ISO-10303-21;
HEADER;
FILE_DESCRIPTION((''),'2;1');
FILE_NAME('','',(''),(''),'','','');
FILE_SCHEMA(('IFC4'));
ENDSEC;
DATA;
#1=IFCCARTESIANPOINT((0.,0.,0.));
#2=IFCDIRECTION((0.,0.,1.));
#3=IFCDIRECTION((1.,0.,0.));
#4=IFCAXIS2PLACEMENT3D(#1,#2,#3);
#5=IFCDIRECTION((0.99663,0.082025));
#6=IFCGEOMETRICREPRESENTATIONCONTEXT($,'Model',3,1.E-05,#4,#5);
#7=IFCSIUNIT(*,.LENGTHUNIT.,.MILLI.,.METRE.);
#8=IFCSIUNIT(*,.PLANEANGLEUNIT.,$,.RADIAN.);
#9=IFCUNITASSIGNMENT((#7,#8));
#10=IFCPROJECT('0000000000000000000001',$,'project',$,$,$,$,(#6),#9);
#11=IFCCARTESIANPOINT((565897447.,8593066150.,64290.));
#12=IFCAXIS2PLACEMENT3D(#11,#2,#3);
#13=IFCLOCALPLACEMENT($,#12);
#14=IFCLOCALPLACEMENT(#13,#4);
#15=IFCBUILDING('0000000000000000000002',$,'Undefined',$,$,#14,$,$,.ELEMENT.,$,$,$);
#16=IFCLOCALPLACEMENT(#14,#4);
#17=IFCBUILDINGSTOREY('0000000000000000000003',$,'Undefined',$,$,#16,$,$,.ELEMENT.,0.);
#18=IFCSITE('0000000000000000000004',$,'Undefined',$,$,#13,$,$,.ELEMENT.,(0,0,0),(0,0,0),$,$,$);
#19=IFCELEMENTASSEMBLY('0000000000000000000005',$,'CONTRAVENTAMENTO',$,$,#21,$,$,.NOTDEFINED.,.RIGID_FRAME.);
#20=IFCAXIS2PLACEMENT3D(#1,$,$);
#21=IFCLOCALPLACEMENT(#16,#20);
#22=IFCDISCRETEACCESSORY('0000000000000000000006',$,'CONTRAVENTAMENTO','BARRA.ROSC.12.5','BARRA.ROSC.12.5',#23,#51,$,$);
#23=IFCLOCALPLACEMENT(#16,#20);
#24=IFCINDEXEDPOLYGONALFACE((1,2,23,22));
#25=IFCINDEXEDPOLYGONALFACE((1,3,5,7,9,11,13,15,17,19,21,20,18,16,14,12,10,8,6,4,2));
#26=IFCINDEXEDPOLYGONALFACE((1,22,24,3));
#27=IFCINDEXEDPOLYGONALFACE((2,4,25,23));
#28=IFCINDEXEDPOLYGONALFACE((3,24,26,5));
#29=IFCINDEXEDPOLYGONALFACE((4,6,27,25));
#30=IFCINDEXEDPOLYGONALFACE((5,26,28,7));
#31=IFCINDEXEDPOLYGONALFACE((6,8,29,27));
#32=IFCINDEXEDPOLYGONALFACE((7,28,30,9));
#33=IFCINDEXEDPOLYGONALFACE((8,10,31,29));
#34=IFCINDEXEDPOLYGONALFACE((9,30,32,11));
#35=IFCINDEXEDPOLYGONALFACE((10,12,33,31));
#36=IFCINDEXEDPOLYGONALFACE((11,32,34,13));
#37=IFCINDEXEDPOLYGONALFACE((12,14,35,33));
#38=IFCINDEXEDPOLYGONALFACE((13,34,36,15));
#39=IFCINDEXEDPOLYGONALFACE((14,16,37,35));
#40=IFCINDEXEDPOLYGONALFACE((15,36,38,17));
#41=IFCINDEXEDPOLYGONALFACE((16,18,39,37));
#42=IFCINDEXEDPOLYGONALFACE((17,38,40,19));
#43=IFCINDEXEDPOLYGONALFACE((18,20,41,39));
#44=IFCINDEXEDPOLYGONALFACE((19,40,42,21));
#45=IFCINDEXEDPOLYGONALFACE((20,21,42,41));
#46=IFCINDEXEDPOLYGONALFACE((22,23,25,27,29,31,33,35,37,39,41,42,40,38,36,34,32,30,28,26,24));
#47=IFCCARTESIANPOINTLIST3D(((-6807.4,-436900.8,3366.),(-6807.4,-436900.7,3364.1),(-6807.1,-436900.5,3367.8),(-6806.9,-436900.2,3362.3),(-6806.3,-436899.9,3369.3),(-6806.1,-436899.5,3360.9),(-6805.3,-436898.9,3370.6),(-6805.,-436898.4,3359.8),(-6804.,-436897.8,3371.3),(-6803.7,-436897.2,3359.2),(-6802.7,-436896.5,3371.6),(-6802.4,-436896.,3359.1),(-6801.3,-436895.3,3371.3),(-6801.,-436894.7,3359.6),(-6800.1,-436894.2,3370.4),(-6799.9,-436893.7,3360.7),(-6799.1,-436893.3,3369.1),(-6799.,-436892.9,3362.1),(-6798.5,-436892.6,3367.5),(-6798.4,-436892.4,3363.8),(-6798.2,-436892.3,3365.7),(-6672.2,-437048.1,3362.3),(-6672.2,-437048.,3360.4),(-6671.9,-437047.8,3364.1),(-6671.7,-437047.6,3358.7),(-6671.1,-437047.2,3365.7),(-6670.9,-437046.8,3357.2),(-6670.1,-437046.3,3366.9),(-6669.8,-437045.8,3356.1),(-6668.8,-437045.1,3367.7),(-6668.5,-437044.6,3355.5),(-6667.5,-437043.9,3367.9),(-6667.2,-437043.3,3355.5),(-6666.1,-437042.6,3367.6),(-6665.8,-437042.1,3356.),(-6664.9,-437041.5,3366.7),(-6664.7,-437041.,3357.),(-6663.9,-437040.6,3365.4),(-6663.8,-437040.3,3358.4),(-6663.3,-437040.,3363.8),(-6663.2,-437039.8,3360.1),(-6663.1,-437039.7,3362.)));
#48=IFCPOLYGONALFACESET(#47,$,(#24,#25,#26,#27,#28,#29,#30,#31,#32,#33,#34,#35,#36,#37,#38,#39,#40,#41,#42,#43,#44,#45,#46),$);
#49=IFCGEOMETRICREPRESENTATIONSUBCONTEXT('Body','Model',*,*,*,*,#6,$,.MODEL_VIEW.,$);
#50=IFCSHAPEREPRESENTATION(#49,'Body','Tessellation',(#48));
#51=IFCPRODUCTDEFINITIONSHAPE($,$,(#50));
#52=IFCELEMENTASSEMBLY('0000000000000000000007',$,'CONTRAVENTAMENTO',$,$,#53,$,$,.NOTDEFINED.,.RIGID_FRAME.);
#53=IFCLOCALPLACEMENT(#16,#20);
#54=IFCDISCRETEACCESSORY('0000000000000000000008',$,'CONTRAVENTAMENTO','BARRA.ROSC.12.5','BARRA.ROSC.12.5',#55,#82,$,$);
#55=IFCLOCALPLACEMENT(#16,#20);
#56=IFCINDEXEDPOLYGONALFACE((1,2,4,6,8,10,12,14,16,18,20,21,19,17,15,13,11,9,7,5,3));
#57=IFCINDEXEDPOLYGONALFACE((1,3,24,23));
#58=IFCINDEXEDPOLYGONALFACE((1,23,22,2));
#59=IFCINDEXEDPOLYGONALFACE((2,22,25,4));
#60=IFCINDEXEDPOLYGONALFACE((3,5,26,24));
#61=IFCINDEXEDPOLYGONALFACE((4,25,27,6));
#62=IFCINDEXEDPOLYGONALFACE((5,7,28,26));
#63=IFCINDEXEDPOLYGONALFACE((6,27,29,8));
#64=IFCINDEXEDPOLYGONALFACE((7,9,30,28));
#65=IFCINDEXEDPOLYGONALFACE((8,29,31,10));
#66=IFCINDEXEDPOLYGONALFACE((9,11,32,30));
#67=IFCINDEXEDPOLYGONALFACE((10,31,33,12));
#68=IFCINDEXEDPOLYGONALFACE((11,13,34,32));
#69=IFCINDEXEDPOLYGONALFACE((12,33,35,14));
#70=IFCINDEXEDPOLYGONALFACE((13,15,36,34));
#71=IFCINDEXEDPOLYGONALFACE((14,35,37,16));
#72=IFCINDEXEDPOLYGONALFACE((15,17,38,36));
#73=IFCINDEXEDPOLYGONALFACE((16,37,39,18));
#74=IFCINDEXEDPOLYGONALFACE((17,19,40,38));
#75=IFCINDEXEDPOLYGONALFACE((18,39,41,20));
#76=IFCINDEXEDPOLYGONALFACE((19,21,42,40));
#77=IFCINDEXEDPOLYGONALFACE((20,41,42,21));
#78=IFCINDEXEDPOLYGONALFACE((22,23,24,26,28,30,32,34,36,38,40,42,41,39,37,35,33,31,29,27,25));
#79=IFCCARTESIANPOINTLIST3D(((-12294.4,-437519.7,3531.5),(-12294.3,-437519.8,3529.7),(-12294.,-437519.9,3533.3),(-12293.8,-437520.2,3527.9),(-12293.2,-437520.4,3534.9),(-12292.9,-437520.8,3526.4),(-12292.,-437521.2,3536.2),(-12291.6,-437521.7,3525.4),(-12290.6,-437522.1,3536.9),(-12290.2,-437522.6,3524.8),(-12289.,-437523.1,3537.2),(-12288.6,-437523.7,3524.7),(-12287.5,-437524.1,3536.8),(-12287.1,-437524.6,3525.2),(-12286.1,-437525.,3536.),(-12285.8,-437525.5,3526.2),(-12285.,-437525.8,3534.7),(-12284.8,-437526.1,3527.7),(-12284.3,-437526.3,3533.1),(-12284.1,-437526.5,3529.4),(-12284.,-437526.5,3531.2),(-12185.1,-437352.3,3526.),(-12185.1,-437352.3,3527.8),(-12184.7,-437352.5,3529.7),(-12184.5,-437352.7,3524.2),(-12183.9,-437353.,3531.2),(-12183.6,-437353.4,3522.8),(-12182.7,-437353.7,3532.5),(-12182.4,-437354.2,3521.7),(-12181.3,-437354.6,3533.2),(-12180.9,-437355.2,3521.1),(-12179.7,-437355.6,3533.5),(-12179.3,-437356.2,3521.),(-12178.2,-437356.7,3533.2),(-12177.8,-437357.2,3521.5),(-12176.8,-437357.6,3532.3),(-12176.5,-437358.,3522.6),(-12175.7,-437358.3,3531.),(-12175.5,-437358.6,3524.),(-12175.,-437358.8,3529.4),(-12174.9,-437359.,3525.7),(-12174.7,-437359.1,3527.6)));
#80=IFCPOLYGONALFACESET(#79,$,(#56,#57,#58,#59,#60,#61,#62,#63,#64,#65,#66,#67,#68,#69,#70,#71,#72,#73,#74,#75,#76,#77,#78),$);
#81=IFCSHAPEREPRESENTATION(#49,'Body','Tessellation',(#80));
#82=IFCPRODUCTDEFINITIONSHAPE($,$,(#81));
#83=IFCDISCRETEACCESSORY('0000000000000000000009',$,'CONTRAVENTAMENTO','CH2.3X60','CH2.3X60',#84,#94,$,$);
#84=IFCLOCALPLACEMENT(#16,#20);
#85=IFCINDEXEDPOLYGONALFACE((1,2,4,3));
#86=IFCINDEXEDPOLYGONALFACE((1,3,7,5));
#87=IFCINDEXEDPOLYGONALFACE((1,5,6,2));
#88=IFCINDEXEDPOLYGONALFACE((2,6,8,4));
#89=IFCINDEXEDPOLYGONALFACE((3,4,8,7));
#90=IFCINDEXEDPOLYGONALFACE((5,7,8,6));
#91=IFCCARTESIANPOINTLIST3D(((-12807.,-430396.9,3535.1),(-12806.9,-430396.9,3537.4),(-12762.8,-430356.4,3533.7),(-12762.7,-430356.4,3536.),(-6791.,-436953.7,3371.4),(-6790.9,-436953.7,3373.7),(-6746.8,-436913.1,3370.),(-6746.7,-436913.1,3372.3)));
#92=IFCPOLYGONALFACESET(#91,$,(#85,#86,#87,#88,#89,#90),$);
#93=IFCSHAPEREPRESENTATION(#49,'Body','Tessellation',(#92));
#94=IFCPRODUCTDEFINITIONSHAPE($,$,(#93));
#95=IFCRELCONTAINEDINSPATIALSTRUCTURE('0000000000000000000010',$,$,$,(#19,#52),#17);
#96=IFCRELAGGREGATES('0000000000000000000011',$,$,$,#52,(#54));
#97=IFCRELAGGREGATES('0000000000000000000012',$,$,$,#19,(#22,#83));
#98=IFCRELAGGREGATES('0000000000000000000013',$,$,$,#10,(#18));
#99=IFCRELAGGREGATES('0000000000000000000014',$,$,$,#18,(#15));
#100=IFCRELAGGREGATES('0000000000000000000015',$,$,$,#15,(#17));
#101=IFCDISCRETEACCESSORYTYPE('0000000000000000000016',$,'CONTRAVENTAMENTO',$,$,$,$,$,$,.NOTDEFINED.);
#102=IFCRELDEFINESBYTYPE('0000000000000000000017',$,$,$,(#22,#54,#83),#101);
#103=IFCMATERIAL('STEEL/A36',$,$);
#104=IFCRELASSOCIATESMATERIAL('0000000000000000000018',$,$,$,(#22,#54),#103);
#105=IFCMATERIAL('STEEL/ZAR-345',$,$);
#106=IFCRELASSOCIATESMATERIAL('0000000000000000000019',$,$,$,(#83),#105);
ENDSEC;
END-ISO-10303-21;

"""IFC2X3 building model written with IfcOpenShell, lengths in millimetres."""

from ifc_helpers import new_model, si_unit, direction, frame, origin_with_axes, origin_2d_with_axis, place, context, subcontext, project, spatial, polyline, circle, outline, extrude, material, type_object, element, aggregate, save


model = new_model("IFC2X3")

# Units and contexts
model_context = context("Model", 3, precision=1e-05, world=origin_with_axes(), true_north=direction((0.99663, 0.082025)))
body_context = subcontext(model_context, "Body", "Model", "MODEL_VIEW")
ifc_project = project(units=[si_unit("LENGTHUNIT", "METRE", prefix="MILLI"), si_unit("PLANEANGLEUNIT", "RADIAN")], contexts=[model_context])

# Site, building, storey
site_placement = place(None, frame((565897447.0, 8593066150.0, 64290.0), z_axis=(0.0, 0.0, 1.0), x_axis=(1.0, 0.0, 0.0)))
site = spatial("IfcSite", under=ifc_project, at=site_placement, Name="Undefined", CompositionType="ELEMENT", RefLatitude=(0, 0, 0), RefLongitude=(0, 0, 0))
building_placement = place(site_placement, origin_with_axes())
building = spatial("IfcBuilding", under=site, at=building_placement, Name="Undefined", CompositionType="ELEMENT")
storey_placement = place(building_placement, origin_with_axes())
storey = spatial("IfcBuildingStorey", under=building, at=storey_placement, Name="Undefined", CompositionType="ELEMENT", Elevation=0.0)

# Shared definitions
ifc_material_1 = material(Name="STEEL/A36")

# Element assemblies, discrete accessories
discrete_accessory_type_1 = type_object("IfcDiscreteAccessoryType", Name="CONTRAVENTAMENTO")
assembly_1_placement = place(storey_placement, origin_with_axes())
assembly_1 = element("IfcElementAssembly", 1, at=assembly_1_placement, inside=storey, Name="CONTRAVENTAMENTO", AssemblyPlace="NOTDEFINED", PredefinedType="RIGID_FRAME")
discrete_accessory_1_placement = place(assembly_1_placement, frame((-6667.7, -437043.9, 3361.7), z_axis=(-0.736334, -0.676203, 0.02368), x_axis=(-0.675958, 0.736711, 0.018398)))
discrete_accessory_1 = element("IfcDiscreteAccessory", 2, at=discrete_accessory_1_placement, type_object=discrete_accessory_type_1, material=ifc_material_1, Name="CONTRAVENTAMENTO", Description="BARRA.ROSC.12.5", ObjectType="BARRA.ROSC.12.5", context=body_context, shape_type="SweptSolid", body=[
    extrude(circle(Radius=6.2, at=origin_2d_with_axis()), frame((200.0, 0.0, 0.0), z_axis=(-1.0, 0.0, 0.0), x_axis=(0.0, -1.0, 0.0)), (0.0, 0.0, 1.0), 200.0),
])
assembly_2_placement = place(storey_placement, origin_with_axes())
assembly_2 = element("IfcElementAssembly", 3, at=assembly_2_placement, inside=storey, Name="CONTRAVENTAMENTO", AssemblyPlace="NOTDEFINED", PredefinedType="RIGID_FRAME")
discrete_accessory_2_placement = place(assembly_2_placement, frame((-12289.2, -437523.1, 3530.9), z_axis=(-0.836984, 0.546715, 0.02368), x_axis=(0.546411, 0.837315, -0.018398)))
discrete_accessory_2 = element("IfcDiscreteAccessory", 4, at=discrete_accessory_2_placement, type_object=discrete_accessory_type_1, material=ifc_material_1, Name="CONTRAVENTAMENTO", Description="BARRA.ROSC.12.5", ObjectType="BARRA.ROSC.12.5", context=body_context, shape_type="SweptSolid", body=[
    extrude(circle(Radius=6.2, at=origin_2d_with_axis()), frame((200.0, 0.0, 0.0), z_axis=(-1.0, 0.0, 0.0), x_axis=(0.0, -1.0, 0.0)), (0.0, 0.0, 1.0), 200.0),
])
aggregate(assembly_2, [discrete_accessory_2])

# Discrete accessory
ifc_material_2 = material(Name="STEEL/ZAR-345")
discrete_accessory_3_placement = place(assembly_1_placement, frame((-6768.8, -436933.4, 3371.8), z_axis=(0.029885, 0.00246, 0.99955), x_axis=(-0.675958, 0.736711, 0.018398)))
discrete_accessory_3 = element("IfcDiscreteAccessory", 5, at=discrete_accessory_3_placement, type_object=discrete_accessory_type_1, material=ifc_material_2, Name="CONTRAVENTAMENTO", Description="CH2.3X60", ObjectType="CH2.3X60", context=body_context, shape_type="SweptSolid", body=[
    extrude(outline(polyline([(8900.0, -30.0), (0.0, -30.0), (0.0, 30.0), (8900.0, 30.0), (8900.0, -30.0)])), frame((0.0, 0.0, -1.1), z_axis=(0.0, 0.0, 1.0), x_axis=(1.0, 0.0, 0.0)), (0.0, 0.0, 1.0), 2.3),
])
aggregate(assembly_1, [discrete_accessory_1, discrete_accessory_3])

save(model, "model.ifc")
